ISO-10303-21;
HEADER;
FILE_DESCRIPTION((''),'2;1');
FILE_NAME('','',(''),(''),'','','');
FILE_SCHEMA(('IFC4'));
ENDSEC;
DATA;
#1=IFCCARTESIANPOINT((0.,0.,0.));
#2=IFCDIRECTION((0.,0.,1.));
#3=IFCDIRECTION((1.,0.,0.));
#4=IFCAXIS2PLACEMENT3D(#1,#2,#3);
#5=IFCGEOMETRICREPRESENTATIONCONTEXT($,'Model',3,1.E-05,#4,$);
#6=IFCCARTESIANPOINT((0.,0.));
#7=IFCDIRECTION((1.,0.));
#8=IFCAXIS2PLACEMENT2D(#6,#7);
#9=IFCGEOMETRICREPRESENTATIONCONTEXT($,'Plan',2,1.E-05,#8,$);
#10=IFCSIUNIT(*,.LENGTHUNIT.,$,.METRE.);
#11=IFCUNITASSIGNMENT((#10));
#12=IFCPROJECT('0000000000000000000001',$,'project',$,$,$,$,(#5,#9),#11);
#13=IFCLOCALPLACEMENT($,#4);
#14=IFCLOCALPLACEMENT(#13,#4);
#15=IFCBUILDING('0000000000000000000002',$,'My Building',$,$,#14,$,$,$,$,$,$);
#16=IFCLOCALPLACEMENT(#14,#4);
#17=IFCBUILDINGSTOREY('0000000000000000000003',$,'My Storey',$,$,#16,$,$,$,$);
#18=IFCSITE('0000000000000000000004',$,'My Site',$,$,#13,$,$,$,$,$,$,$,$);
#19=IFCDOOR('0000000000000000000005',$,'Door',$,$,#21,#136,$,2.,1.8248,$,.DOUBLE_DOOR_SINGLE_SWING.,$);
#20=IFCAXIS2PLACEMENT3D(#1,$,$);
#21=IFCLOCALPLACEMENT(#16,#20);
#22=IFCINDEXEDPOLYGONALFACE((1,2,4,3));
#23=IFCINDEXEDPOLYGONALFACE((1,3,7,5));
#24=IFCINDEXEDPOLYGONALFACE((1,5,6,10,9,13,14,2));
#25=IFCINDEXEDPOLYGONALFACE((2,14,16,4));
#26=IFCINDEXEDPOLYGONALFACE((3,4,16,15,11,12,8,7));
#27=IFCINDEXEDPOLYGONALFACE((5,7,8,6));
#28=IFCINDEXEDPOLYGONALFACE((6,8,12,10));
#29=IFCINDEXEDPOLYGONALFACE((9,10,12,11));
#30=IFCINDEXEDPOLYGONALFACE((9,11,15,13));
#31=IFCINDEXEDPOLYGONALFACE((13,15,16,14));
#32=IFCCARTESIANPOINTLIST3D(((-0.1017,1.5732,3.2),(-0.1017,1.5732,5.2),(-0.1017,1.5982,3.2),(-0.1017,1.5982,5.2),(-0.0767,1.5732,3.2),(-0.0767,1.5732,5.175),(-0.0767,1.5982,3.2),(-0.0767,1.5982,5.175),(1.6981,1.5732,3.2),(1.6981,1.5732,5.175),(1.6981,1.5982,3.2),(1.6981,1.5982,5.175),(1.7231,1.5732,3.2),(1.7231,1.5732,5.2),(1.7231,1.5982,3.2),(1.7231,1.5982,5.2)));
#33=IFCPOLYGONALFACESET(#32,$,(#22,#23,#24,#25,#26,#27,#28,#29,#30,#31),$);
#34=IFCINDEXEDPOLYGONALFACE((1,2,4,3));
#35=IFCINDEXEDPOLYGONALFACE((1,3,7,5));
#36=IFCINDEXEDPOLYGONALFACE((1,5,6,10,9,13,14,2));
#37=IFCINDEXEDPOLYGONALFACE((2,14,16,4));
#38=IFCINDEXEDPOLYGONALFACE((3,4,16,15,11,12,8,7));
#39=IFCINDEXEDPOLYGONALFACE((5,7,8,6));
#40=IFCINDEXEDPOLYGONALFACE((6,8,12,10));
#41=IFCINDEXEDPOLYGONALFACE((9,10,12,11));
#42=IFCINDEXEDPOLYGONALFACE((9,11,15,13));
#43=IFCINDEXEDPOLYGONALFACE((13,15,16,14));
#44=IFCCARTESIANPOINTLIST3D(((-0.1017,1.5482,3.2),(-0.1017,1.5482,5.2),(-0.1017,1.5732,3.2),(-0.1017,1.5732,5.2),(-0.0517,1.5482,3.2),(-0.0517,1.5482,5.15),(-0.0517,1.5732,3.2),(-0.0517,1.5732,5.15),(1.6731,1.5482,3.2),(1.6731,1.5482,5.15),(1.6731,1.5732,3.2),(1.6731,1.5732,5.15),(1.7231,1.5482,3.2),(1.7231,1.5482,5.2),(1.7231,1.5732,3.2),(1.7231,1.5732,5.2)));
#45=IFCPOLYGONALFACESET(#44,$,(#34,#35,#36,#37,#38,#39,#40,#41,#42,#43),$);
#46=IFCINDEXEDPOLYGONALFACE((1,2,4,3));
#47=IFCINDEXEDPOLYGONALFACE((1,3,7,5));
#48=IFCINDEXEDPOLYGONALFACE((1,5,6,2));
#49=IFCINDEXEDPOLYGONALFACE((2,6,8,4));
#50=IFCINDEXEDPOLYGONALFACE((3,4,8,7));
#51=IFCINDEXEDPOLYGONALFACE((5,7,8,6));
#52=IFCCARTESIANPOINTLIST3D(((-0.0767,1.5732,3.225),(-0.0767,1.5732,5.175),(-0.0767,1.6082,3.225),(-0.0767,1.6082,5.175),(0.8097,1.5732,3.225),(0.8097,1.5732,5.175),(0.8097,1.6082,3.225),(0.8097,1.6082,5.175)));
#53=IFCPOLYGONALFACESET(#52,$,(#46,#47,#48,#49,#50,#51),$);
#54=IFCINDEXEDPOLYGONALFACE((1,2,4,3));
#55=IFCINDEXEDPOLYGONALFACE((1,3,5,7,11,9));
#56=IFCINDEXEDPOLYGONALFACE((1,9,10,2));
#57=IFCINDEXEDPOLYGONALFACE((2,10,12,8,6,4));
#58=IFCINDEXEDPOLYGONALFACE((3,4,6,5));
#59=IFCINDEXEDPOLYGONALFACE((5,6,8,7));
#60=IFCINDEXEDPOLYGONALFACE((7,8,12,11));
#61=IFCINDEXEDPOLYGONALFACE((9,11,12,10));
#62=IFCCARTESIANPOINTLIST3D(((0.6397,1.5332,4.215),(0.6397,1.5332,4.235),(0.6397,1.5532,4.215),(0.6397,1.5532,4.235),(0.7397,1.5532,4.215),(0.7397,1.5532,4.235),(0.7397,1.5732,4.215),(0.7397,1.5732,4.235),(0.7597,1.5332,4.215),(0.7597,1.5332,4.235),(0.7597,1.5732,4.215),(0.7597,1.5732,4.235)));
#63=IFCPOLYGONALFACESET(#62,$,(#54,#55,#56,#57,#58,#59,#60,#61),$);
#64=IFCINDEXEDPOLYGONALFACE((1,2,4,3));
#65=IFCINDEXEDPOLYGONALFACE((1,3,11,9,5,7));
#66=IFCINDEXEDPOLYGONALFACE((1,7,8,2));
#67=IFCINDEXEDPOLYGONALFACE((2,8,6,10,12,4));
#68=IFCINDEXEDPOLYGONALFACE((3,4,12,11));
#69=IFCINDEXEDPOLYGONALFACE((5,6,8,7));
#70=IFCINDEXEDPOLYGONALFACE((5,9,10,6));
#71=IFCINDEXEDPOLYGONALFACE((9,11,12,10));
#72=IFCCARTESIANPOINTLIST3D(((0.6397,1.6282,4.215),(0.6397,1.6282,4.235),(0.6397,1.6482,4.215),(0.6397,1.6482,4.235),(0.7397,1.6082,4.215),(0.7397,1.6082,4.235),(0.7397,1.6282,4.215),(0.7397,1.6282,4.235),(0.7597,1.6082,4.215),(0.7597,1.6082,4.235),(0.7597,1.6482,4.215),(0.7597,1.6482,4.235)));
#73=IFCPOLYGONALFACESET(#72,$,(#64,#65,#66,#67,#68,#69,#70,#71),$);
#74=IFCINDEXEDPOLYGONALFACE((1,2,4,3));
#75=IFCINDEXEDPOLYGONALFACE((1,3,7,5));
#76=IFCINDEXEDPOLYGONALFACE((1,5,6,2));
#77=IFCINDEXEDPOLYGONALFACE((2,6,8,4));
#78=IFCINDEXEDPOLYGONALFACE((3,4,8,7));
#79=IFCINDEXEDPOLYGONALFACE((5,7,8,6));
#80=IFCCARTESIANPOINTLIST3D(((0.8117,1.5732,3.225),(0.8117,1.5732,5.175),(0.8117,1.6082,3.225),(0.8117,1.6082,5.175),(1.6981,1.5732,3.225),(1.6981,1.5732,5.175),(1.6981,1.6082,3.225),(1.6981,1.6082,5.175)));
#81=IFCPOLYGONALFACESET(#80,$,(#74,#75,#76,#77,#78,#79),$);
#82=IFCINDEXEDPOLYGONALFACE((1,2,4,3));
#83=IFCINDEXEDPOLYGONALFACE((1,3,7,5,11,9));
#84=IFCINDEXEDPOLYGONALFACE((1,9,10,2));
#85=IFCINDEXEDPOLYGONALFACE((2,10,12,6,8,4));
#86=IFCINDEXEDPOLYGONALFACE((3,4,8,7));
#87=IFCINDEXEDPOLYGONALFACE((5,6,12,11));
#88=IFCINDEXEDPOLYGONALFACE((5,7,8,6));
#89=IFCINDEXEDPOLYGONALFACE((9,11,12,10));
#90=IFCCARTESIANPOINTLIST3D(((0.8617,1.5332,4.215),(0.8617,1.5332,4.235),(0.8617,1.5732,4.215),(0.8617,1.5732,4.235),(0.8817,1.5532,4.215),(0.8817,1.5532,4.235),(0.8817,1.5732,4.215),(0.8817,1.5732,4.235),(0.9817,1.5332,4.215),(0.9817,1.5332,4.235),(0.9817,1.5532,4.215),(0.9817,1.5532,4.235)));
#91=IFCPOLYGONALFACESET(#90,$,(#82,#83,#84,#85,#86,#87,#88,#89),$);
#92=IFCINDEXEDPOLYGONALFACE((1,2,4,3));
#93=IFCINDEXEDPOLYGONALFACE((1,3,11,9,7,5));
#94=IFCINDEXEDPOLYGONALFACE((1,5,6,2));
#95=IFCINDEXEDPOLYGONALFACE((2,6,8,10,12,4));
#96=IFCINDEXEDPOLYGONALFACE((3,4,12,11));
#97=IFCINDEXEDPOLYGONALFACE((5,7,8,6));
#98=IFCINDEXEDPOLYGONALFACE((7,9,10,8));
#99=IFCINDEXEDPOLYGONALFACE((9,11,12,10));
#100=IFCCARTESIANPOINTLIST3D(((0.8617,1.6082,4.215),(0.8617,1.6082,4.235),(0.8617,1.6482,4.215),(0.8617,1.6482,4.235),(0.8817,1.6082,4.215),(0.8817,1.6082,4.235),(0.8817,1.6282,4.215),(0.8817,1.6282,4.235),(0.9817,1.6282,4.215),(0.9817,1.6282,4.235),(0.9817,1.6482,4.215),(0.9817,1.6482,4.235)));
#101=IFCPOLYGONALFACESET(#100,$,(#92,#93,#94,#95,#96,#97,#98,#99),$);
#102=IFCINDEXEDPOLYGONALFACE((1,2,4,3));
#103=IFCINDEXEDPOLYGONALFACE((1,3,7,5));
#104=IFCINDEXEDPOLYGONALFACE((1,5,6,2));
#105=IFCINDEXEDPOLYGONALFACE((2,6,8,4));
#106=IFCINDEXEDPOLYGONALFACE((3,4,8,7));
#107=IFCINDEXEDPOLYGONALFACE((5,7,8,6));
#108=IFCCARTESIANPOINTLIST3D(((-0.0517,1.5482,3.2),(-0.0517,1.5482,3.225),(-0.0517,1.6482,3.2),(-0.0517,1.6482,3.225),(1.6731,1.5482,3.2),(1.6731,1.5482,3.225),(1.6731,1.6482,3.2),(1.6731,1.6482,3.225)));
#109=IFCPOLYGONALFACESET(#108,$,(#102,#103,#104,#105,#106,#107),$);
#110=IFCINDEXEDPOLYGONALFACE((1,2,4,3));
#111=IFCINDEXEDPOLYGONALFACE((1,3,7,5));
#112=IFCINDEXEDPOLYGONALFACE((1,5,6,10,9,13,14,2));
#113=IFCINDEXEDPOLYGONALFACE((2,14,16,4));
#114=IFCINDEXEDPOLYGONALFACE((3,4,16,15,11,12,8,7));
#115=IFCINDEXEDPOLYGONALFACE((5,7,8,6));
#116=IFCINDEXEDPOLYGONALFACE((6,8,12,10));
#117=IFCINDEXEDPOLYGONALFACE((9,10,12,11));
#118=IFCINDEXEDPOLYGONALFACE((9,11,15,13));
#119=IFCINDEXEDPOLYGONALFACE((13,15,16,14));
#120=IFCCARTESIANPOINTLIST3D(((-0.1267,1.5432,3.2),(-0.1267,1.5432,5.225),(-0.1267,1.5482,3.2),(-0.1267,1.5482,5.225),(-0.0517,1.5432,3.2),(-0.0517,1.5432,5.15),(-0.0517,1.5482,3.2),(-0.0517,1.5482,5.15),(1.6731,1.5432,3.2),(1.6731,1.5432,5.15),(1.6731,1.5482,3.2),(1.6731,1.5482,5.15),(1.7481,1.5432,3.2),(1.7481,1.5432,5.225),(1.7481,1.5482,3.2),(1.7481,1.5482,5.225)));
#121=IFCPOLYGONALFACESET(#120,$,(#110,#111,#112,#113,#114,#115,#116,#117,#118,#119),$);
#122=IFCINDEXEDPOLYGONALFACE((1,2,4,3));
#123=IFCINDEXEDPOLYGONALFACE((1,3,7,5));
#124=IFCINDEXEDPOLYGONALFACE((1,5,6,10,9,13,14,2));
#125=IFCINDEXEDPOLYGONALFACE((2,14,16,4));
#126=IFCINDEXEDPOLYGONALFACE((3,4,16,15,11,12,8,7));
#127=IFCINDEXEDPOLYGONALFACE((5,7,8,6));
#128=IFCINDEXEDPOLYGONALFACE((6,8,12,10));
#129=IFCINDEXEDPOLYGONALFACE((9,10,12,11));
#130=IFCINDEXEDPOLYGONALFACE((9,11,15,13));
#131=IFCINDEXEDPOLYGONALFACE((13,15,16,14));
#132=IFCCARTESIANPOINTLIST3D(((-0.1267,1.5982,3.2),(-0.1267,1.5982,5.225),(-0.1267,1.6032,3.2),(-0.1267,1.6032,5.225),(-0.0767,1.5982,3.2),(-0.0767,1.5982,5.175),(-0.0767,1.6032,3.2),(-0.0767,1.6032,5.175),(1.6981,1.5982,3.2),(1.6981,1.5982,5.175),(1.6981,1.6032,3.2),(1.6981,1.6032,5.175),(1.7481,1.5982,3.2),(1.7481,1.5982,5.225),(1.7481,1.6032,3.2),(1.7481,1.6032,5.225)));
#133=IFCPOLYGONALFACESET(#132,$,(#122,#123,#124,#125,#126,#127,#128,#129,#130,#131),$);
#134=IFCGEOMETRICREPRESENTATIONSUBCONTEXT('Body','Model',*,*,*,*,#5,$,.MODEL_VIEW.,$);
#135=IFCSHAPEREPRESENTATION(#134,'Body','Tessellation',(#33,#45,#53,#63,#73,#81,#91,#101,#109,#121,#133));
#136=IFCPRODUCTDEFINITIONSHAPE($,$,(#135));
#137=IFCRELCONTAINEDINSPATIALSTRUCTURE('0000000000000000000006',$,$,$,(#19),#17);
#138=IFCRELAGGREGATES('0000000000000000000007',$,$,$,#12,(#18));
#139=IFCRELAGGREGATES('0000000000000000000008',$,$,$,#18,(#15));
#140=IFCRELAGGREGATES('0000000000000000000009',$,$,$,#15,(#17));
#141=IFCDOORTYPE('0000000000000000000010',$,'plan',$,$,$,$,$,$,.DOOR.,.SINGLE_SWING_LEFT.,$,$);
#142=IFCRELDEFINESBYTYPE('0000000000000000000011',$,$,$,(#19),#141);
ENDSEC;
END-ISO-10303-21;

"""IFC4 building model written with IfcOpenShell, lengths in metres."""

from ifc_helpers import new_model, entity, si_unit, frame, origin_with_axes, origin_2d_with_axis, place, context, subcontext, project, spatial, line, indexed_curve, outline, extrude, shape, source, transform, mapped, type_object, type_shapes, element, save


model = new_model("IFC4")

# Units and contexts
model_context = context("Model", 3, precision=1e-05, world=origin_with_axes())
plan_context = context("Plan", 2, precision=1e-05, world=origin_2d_with_axis())
body_context_1 = subcontext(model_context, "Body", "Model", "MODEL_VIEW")
body_context_2 = subcontext(plan_context, "Body", "Plan", "PLAN_VIEW")
ifc_project = project(units=[si_unit("LENGTHUNIT", "METRE")], contexts=[model_context, plan_context])

# Site, building, storey
site_placement = place(None, origin_with_axes())
site = spatial("IfcSite", under=ifc_project, at=site_placement, Name="My Site")
building_placement = place(site_placement, origin_with_axes())
building = spatial("IfcBuilding", under=site, at=building_placement, Name="My Building")
storey_placement = place(building_placement, origin_with_axes())
storey = spatial("IfcBuildingStorey", under=building, at=storey_placement, Name="My Storey")

# Door
door_type_1 = type_object("IfcDoorType", Name="plan", OperationType="SINGLE_SWING_LEFT", PredefinedType="DOOR")
shared_shape_1 = source(origin_with_axes(), body_context_1, "Body", "SweptSolid", [
    extrude(outline(indexed_curve([(0.0, 0.0), (0.0, 2.0), (1.8248, 2.0), (1.8248, 0.0), (1.7998, 0.0), (1.7998, 1.975), (0.025, 1.975), (0.025, 0.0)], segments=[line(1, 2, 3, 4, 5, 6, 7, 8, 1)])), frame((0.0, 0.025, 0.0), z_axis=(0.0, -1.0, 0.0), x_axis=(1.0, 0.0, 0.0)), (0.0, 0.0, -1.0), 0.025),
    extrude(outline(indexed_curve([(0.0, 0.0), (0.0, 2.0), (1.8248, 2.0), (1.8248, 0.0), (1.7748, 0.0), (1.7748, 1.95), (0.05, 1.95), (0.05, 0.0)], segments=[line(1, 2, 3, 4, 5, 6, 7, 8, 1)])), frame((0.0, 0.0, 0.0), z_axis=(0.0, -1.0, 0.0), x_axis=(1.0, 0.0, 0.0)), (0.0, 0.0, -1.0), 0.025),
    extrude(outline(indexed_curve([(0.0, 0.0), (0.8864, 0.0), (0.8864, 0.035), (0.0, 0.035)], segments=[line(1, 2, 3, 4, 1)])), frame((0.025, 0.025, 0.025), z_axis=(0.0, 0.0, 1.0), x_axis=(1.0, 0.0, 0.0)), (0.0, 0.0, 1.0), 1.95),
    extrude(outline(indexed_curve([(0.0, 0.0), (0.0, -0.04), (-0.12, -0.04), (-0.12, -0.02), (-0.02, -0.02), (-0.02, 0.0)], segments=[line(1, 2, 3, 4, 5, 6, 1)])), frame((0.8614, 0.025, 1.015), z_axis=(0.0, 0.0, 1.0), x_axis=(1.0, 0.0, 0.0)), (0.0, 0.0, 1.0), 0.02),
    extrude(outline(indexed_curve([(0.0, 0.0), (0.0, 0.04), (-0.12, 0.04), (-0.12, 0.02), (-0.02, 0.02), (-0.02, 0.0)], segments=[line(1, 2, 3, 4, 5, 6, 1)])), frame((0.8614, 0.06, 1.015), z_axis=(0.0, 0.0, 1.0), x_axis=(1.0, 0.0, 0.0)), (0.0, 0.0, 1.0), 0.02),
    extrude(outline(indexed_curve([(0.0, 0.0), (-0.8864, 0.0), (-0.8864, 0.035), (0.0, 0.035)], segments=[line(1, 2, 3, 4, 1)])), frame((1.7998, 0.025, 0.025), z_axis=(0.0, 0.0, 1.0), x_axis=(1.0, 0.0, 0.0)), (0.0, 0.0, 1.0), 1.95),
    extrude(outline(indexed_curve([(0.0, 0.0), (0.0, -0.04), (0.12, -0.04), (0.12, -0.02), (0.02, -0.02), (0.02, 0.0)], segments=[line(1, 2, 3, 4, 5, 6, 1)])), frame((0.9634, 0.025, 1.015), z_axis=(0.0, 0.0, 1.0), x_axis=(1.0, 0.0, 0.0)), (0.0, 0.0, 1.0), 0.02),
    extrude(outline(indexed_curve([(0.0, 0.0), (0.0, 0.04), (0.12, 0.04), (0.12, 0.02), (0.02, 0.02), (0.02, 0.0)], segments=[line(1, 2, 3, 4, 5, 6, 1)])), frame((0.9634, 0.06, 1.015), z_axis=(0.0, 0.0, 1.0), x_axis=(1.0, 0.0, 0.0)), (0.0, 0.0, 1.0), 0.02),
    extrude(outline(indexed_curve([(0.0, 0.0), (1.7248, 0.0), (1.7248, 0.1), (0.0, 0.1)], segments=[line(1, 2, 3, 4, 1)])), frame((0.05, 0.0, 0.0), z_axis=(0.0, 0.0, 1.0), x_axis=(1.0, 0.0, 0.0)), (0.0, 0.0, 1.0), 0.025),
    extrude(outline(indexed_curve([(0.0, 0.0), (0.0, 2.025), (1.8748, 2.025), (1.8748, 0.0), (1.7998, 0.0), (1.7998, 1.95), (0.075, 1.95), (0.075, 0.0)], segments=[line(1, 2, 3, 4, 5, 6, 7, 8, 1)])), frame((-0.025, -0.005, 0.0), z_axis=(0.0, -1.0, 0.0), x_axis=(1.0, 0.0, 0.0)), (0.0, 0.0, -1.0), 0.005),
    extrude(outline(indexed_curve([(0.0, 0.0), (0.0, 2.025), (1.8748, 2.025), (1.8748, 0.0), (1.8248, 0.0), (1.8248, 1.975), (0.05, 1.975), (0.05, 0.0)], segments=[line(1, 2, 3, 4, 5, 6, 7, 8, 1)])), frame((-0.025, 0.05, 0.0), z_axis=(0.0, -1.0, 0.0), x_axis=(1.0, 0.0, 0.0)), (0.0, 0.0, -1.0), 0.005),
])
shared_shape_2 = source(origin_with_axes(), body_context_2, "Body", "Curve2D", [
    entity("IfcIndexedPolyCurve", entity("IfcCartesianPointList2D", [[0.0, 0.0], [0.0, 0.05], [0.025, 0.05], [0.025, 0.025], [0.05, 0.025], [0.05, 0.0]]), [entity("IfcLineIndex", [1, 2, 3, 4, 5, 6, 1])]),
    entity("IfcIndexedPolyCurve", entity("IfcCartesianPointList2D", [[1.8248, 0.0], [1.8248, 0.05], [1.7998, 0.05], [1.7998, 0.025], [1.7748, 0.025], [1.7748, 0.0]]), [entity("IfcLineIndex", [1, 2, 3, 4, 5, 6, 1])]),
    entity("IfcTrimmedCurve", entity("IfcEllipse", entity("IfcAxis2Placement2D", entity("IfcCartesianPoint", [0.06, 0.05]), entity("IfcDirection", [1.0, 0.0])), 0.8524, 0.8874), [entity("IfcCartesianPoint", [0.9124, 0.05])], [entity("IfcCartesianPoint", [0.06, 0.9374])], True, "CARTESIAN"),
    entity("IfcIndexedPolyCurve", entity("IfcCartesianPointList2D", [[0.025, 0.05], [0.06, 0.05], [0.06, 0.9374], [0.025, 0.9374]]), [entity("IfcLineIndex", [1, 2, 3, 4, 1])]),
    entity("IfcTrimmedCurve", entity("IfcEllipse", entity("IfcAxis2Placement2D", entity("IfcCartesianPoint", [1.7648, 0.05]), entity("IfcDirection", [1.0, 0.0])), 0.8524, 0.8874), [entity("IfcCartesianPoint", [1.7648, 0.9374])], [entity("IfcCartesianPoint", [0.9124, 0.05])], True, "CARTESIAN"),
    entity("IfcIndexedPolyCurve", entity("IfcCartesianPointList2D", [[1.7998, 0.05], [1.7648, 0.05], [1.7648, 0.9374], [1.7998, 0.9374]]), [entity("IfcLineIndex", [1, 2, 3, 4, 1])]),
])
type_shapes(door_type_1, [shared_shape_1, shared_shape_2])
door_1_placement = place(storey_placement, frame((-0.1017, 1.5482, 3.2), z_axis=(0.0, 0.0, 1.0), x_axis=(1.0, 0.0, 0.0)))
element("IfcDoor", 1, at=door_1_placement, inside=storey, type_object=door_type_1, Name="Door", OperationType="DOUBLE_DOOR_SINGLE_SWING", OverallHeight=2.0, OverallWidth=1.8248, shapes=[
    shape(body_context_1, "Body", "MappedRepresentation", [mapped(shared_shape_1, transform((0.0, 0.0, 0.0), x_axis=(1.0, 0.0, 0.0), y_axis=(0.0, 1.0, 0.0), z_axis=(0.0, 0.0, 1.0), scale=1.0))]),
    shape(body_context_2, "Body", "MappedRepresentation", [mapped(shared_shape_2, transform((0.0, 0.0, 0.0), x_axis=(1.0, 0.0, 0.0), y_axis=(0.0, 1.0, 0.0), z_axis=(0.0, 0.0, 1.0), scale=1.0))]),
])

save(model, "model.ifc")
